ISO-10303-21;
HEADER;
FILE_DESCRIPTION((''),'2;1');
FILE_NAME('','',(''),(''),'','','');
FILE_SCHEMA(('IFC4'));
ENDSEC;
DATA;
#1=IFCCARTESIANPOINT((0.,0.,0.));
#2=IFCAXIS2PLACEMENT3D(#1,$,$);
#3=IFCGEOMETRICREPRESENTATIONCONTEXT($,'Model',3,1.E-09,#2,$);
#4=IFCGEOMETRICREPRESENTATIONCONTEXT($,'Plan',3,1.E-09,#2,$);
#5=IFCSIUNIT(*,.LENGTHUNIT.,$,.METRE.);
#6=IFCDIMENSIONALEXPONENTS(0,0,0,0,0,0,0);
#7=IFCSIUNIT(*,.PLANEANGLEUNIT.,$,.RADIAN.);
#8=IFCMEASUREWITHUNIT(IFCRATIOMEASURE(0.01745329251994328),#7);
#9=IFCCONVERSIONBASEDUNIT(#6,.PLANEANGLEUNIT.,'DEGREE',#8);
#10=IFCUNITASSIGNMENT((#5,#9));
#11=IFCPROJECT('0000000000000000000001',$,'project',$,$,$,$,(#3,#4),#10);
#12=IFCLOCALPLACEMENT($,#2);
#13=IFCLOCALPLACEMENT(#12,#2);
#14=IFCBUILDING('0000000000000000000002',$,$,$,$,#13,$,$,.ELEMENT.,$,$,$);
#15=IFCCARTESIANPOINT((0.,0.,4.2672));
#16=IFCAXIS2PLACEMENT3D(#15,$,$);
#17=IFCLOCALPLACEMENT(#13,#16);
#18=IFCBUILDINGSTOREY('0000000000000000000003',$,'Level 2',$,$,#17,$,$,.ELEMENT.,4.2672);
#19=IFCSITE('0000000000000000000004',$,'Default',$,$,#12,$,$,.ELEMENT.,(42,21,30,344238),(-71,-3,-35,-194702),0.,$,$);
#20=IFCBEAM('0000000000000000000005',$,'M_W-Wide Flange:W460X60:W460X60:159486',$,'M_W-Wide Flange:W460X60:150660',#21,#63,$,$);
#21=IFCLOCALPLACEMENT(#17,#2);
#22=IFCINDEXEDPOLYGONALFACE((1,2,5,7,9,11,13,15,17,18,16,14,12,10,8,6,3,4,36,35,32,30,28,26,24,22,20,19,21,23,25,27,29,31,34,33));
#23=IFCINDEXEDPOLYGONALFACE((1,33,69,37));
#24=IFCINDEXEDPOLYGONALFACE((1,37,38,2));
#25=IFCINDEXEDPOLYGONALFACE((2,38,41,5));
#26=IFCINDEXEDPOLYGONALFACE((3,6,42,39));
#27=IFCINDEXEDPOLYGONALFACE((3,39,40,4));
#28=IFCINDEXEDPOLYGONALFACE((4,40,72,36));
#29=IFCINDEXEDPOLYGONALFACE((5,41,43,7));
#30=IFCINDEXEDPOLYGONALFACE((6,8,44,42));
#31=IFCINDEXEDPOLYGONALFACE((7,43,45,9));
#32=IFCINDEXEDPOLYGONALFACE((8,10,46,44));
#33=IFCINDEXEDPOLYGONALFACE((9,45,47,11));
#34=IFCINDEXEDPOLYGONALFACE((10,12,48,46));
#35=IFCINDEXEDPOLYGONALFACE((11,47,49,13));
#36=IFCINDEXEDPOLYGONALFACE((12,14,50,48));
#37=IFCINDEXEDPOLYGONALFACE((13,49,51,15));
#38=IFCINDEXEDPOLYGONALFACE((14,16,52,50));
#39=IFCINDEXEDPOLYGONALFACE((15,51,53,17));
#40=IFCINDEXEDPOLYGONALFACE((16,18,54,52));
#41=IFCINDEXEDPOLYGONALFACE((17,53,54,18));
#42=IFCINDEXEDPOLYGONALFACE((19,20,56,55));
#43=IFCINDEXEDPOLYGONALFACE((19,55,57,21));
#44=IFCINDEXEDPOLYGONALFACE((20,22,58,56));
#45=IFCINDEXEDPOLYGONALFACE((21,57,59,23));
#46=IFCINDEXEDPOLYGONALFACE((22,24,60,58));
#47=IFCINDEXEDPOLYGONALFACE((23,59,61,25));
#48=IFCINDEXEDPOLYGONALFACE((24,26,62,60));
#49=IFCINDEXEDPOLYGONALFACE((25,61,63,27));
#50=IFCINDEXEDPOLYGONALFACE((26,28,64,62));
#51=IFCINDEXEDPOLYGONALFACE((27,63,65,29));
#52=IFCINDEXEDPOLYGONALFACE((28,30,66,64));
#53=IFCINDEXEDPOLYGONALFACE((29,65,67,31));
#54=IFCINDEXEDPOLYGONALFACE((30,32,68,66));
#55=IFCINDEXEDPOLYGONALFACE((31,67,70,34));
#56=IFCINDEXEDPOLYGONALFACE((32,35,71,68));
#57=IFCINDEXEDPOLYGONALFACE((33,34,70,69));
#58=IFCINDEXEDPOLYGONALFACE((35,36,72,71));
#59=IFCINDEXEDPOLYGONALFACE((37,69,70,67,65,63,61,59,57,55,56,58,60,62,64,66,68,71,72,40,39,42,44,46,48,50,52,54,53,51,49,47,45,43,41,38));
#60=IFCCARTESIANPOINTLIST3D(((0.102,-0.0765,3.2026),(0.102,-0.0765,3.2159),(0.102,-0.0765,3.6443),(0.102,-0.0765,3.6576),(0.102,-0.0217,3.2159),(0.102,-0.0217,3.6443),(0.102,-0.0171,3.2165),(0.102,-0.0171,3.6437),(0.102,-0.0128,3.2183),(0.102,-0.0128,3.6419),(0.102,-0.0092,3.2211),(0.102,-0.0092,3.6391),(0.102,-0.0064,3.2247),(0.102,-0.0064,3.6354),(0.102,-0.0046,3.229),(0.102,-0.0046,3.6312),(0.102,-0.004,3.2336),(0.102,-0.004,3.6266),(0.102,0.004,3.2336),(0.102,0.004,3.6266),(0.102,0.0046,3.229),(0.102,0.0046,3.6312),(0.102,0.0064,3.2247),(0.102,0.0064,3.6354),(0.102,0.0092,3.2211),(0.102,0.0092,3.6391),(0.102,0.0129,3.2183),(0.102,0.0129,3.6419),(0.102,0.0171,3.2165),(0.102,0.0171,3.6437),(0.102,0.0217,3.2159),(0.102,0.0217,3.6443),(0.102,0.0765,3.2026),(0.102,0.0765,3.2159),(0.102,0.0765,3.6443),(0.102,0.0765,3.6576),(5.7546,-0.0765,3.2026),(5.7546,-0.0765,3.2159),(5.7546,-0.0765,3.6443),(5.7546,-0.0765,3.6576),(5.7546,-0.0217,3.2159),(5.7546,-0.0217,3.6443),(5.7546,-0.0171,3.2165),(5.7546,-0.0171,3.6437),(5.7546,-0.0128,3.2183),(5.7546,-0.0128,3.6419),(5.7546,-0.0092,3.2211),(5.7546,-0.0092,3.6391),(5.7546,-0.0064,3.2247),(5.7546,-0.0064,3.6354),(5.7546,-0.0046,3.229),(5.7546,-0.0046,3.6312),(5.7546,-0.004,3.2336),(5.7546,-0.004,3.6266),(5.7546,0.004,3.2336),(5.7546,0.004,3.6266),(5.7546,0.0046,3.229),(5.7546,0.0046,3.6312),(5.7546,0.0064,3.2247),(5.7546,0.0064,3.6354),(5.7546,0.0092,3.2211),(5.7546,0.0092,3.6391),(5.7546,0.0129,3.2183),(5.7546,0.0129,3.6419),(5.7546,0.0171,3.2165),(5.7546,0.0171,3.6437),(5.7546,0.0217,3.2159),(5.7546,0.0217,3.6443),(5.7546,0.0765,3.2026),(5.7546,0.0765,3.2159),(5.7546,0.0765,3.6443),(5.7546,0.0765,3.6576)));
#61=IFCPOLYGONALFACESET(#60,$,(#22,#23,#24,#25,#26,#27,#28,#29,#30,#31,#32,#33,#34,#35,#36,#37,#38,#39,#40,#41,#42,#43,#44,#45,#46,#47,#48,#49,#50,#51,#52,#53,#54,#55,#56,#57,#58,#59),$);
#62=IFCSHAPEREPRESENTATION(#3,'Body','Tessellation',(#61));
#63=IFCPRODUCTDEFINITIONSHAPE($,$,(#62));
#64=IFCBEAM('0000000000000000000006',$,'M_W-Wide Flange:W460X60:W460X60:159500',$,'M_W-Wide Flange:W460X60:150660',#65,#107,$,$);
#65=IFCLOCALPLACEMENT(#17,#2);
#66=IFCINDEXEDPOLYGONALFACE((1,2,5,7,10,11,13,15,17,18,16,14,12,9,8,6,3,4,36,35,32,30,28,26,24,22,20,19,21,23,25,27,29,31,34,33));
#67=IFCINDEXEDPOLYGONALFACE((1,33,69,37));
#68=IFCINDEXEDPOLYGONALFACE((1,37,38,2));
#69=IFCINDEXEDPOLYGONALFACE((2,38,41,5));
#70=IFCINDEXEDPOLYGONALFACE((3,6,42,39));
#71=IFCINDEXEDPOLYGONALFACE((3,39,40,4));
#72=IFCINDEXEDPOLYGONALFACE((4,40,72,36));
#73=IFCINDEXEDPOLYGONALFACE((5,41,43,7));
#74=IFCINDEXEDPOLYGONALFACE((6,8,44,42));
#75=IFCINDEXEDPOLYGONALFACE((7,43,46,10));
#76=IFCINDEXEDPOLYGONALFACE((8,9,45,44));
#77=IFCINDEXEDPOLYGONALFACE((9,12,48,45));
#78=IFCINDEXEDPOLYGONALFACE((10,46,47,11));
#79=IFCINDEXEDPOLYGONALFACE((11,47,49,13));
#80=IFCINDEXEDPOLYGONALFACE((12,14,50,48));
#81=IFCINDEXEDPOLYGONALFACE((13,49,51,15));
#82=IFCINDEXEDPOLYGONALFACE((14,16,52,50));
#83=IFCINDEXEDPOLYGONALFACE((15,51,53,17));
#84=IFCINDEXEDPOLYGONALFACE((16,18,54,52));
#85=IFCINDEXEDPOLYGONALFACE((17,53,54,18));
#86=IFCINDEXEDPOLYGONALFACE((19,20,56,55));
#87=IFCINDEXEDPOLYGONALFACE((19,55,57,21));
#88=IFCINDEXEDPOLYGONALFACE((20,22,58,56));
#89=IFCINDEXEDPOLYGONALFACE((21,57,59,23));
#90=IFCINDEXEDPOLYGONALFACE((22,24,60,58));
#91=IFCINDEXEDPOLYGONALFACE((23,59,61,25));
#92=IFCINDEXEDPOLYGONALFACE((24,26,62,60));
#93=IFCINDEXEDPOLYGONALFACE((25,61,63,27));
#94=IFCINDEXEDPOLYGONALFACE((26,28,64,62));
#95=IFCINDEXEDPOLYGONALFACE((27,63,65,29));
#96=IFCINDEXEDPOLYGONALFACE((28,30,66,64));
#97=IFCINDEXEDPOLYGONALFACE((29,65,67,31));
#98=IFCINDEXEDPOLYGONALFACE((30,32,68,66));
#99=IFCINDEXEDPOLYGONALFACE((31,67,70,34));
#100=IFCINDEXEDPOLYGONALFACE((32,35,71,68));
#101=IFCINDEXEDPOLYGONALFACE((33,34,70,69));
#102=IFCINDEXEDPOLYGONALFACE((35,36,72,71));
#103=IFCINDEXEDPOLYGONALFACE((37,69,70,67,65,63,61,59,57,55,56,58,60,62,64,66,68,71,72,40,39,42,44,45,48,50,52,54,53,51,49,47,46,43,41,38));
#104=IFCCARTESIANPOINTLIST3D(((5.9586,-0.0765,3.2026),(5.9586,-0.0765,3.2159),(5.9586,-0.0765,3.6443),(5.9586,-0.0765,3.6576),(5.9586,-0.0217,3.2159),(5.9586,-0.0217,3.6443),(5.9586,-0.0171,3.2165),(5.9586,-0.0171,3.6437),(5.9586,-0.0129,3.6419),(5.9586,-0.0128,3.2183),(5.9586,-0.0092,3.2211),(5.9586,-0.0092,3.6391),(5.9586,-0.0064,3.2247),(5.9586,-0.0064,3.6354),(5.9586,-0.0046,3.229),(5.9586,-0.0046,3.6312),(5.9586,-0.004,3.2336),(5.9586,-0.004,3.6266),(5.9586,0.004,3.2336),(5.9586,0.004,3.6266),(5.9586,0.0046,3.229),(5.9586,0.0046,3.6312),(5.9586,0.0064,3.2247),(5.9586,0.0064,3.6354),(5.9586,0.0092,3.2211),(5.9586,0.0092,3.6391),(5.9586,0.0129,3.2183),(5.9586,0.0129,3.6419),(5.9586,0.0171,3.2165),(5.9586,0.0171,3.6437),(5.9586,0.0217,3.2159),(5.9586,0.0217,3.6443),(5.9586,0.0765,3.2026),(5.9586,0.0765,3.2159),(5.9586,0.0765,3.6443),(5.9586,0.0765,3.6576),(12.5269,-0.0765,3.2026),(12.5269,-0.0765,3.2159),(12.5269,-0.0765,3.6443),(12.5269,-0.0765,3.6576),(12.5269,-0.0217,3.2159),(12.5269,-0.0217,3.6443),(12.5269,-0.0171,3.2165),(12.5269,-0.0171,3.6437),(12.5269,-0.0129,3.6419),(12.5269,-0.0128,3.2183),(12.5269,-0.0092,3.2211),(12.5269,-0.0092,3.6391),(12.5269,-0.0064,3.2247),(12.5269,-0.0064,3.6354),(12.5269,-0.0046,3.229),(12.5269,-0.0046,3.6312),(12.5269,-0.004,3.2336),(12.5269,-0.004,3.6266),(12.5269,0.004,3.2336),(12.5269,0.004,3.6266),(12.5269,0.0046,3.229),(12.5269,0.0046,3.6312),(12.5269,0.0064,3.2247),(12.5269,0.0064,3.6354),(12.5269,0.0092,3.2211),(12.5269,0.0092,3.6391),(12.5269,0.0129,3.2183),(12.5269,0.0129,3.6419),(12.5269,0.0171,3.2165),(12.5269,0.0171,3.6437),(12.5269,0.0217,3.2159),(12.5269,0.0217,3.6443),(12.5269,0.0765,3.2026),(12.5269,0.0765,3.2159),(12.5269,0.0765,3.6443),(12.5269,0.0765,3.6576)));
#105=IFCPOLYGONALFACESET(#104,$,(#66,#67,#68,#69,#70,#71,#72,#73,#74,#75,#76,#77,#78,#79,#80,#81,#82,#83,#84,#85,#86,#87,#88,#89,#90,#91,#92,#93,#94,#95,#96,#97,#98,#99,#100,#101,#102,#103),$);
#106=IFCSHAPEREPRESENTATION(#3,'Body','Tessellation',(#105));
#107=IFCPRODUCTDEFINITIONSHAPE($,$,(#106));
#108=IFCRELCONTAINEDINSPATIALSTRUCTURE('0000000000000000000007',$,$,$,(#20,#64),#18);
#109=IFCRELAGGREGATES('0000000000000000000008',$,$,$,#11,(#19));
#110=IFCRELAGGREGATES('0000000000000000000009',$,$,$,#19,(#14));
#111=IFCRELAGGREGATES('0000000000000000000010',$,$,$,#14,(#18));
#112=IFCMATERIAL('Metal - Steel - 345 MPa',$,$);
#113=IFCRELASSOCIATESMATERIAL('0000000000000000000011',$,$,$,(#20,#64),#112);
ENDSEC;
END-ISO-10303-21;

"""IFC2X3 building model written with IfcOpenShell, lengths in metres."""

from ifc_helpers import new_model, entity, si_unit, converted_unit, frame, frame_2d, origin, place, context, project, spatial, polyline, circle_curve, parameter, trimmed, segment, composite_curve, outline, extrude, material, element, save


model = new_model("IFC2X3")

# Units and contexts
model_context = context("Model", 3, precision=1e-09, world=origin())
plan_context = context("Plan", 3, precision=1e-09, world=origin())
ifc_project = project(units=[si_unit("LENGTHUNIT", "METRE"), converted_unit("PLANEANGLEUNIT", "DEGREE", entity("IfcRatioMeasure", 0.01745329251994328), si_unit("PLANEANGLEUNIT", "RADIAN"), dimensions=[0, 0, 0, 0, 0, 0, 0])], contexts=[model_context, plan_context])

# Site, building, storey
site_placement = place(None, origin())
site = spatial("IfcSite", under=ifc_project, at=site_placement, Name="Default", CompositionType="ELEMENT", RefLatitude=(42, 21, 30, 344238), RefLongitude=(-71, -3, -35, -194702), RefElevation=0.0)
building_placement = place(site_placement, origin())
building = spatial("IfcBuilding", under=site, at=building_placement, CompositionType="ELEMENT")
storey_placement = place(building_placement, frame((0.0, 0.0, 4.2672)))
storey = spatial("IfcBuildingStorey", under=building, at=storey_placement, Name="Level 2", CompositionType="ELEMENT", Elevation=4.2672)

# Shared definitions
ifc_material = material(Name="Metal - Steel - 345 MPa")

# Beams
beam_1_placement = place(storey_placement, frame((0.0, 0.0, 3.6576), z_axis=(0.0, 0.0, 1.0), x_axis=(0.0, -1.0, 0.0)))
element("IfcBeam", 1, at=beam_1_placement, inside=storey, material=ifc_material, Name="M_W-Wide Flange:W460X60:W460X60:159486", ObjectType="M_W-Wide Flange:W460X60:150660", context=model_context, shape_type="SweptSolid", body=[
    extrude(outline(composite_curve([segment(polyline([(-0.0765, -0.2142), (-0.0765, -0.2275)]), True, "CONTINUOUS"), segment(polyline([(-0.0765, -0.2275), (0.0765, -0.2275)]), True, "CONTINUOUS"), segment(polyline([(0.0765, -0.2275), (0.0765, -0.2142)]), True, "CONTINUOUS"), segment(polyline([(0.0765, -0.2142), (0.0217, -0.2142)]), True, "CONTINUOUS"), segment(trimmed(circle_curve(frame_2d((0.0217, -0.1965), x_axis=(1.0, 0.0)), 0.0177), [parameter(180.0)], [parameter(270.0)], True, "PARAMETER"), False, "CONTINUOUS"), segment(polyline([(0.004, -0.1965), (0.004, 0.1965)]), True, "CONTINUOUS"), segment(trimmed(circle_curve(frame_2d((0.0217, 0.1965), x_axis=(1.0, 0.0)), 0.0177), [parameter(90.0)], [parameter(180.0)], True, "PARAMETER"), False, "CONTINUOUS"), segment(polyline([(0.0217, 0.2142), (0.0765, 0.2142)]), True, "CONTINUOUS"), segment(polyline([(0.0765, 0.2142), (0.0765, 0.2275)]), True, "CONTINUOUS"), segment(polyline([(0.0765, 0.2275), (-0.0765, 0.2275)]), True, "CONTINUOUS"), segment(polyline([(-0.0765, 0.2275), (-0.0765, 0.2142)]), True, "CONTINUOUS"), segment(polyline([(-0.0765, 0.2142), (-0.0217, 0.2142)]), True, "CONTINUOUS"), segment(trimmed(circle_curve(frame_2d((-0.0217, 0.1965), x_axis=(1.0, 0.0)), 0.0177), [parameter(360.0)], [parameter(90.0)], True, "PARAMETER"), False, "CONTINUOUS"), segment(polyline([(-0.004, 0.1965), (-0.004, -0.1965)]), True, "CONTINUOUS"), segment(trimmed(circle_curve(frame_2d((-0.0217, -0.1965), x_axis=(1.0, 0.0)), 0.0177), [parameter(270.0)], [parameter(0.0)], True, "PARAMETER"), False, "CONTINUOUS"), segment(polyline([(-0.0217, -0.2142), (-0.0765, -0.2142)]), True, "CONTINUOUS")], self_intersect=False)), frame((0.0, 0.102, -0.2275), z_axis=(0.0, -1.0, 0.0), x_axis=(1.0, 0.0, 0.0)), (0.0, 0.0, -1.0), 5.6526),
])
beam_2_placement = place(storey_placement, frame((5.8566, 0.0, 3.6576), z_axis=(0.0, 0.0, 1.0), x_axis=(0.0, -1.0, 0.0)))
element("IfcBeam", 2, at=beam_2_placement, inside=storey, material=ifc_material, Name="M_W-Wide Flange:W460X60:W460X60:159500", ObjectType="M_W-Wide Flange:W460X60:150660", context=model_context, shape_type="SweptSolid", body=[
    extrude(outline(composite_curve([segment(polyline([(-0.0765, -0.2142), (-0.0765, -0.2275)]), True, "CONTINUOUS"), segment(polyline([(-0.0765, -0.2275), (0.0765, -0.2275)]), True, "CONTINUOUS"), segment(polyline([(0.0765, -0.2275), (0.0765, -0.2142)]), True, "CONTINUOUS"), segment(polyline([(0.0765, -0.2142), (0.0217, -0.2142)]), True, "CONTINUOUS"), segment(trimmed(circle_curve(frame_2d((0.0217, -0.1965), x_axis=(0.0, -1.0)), 0.0177), [parameter(270.0)], [parameter(360.0)], True, "PARAMETER"), False, "CONTINUOUS"), segment(polyline([(0.004, -0.1965), (0.004, 0.1965)]), True, "CONTINUOUS"), segment(trimmed(circle_curve(frame_2d((0.0217, 0.1965), x_axis=(-1.0, 0.0)), 0.0177), [parameter(270.0)], [parameter(360.0)], True, "PARAMETER"), False, "CONTINUOUS"), segment(polyline([(0.0217, 0.2142), (0.0765, 0.2142)]), True, "CONTINUOUS"), segment(polyline([(0.0765, 0.2142), (0.0765, 0.2275)]), True, "CONTINUOUS"), segment(polyline([(0.0765, 0.2275), (-0.0765, 0.2275)]), True, "CONTINUOUS"), segment(polyline([(-0.0765, 0.2275), (-0.0765, 0.2142)]), True, "CONTINUOUS"), segment(polyline([(-0.0765, 0.2142), (-0.0217, 0.2142)]), True, "CONTINUOUS"), segment(trimmed(circle_curve(frame_2d((-0.0217, 0.1965), x_axis=(0.0, 1.0)), 0.0177), [parameter(270.0)], [parameter(360.0)], True, "PARAMETER"), False, "CONTINUOUS"), segment(polyline([(-0.004, 0.1965), (-0.004, -0.1965)]), True, "CONTINUOUS"), segment(trimmed(circle_curve(frame_2d((-0.0217, -0.1965), x_axis=(1.0, 0.0)), 0.0177), [parameter(270.0)], [parameter(0.0)], True, "PARAMETER"), False, "CONTINUOUS"), segment(polyline([(-0.0217, -0.2142), (-0.0765, -0.2142)]), True, "CONTINUOUS")], self_intersect=False)), frame((0.0, 0.102, -0.2275), z_axis=(0.0, -1.0, 0.0), x_axis=(1.0, 0.0, 0.0)), (0.0, 0.0, -1.0), 6.5683),
])

save(model, "model.ifc")
